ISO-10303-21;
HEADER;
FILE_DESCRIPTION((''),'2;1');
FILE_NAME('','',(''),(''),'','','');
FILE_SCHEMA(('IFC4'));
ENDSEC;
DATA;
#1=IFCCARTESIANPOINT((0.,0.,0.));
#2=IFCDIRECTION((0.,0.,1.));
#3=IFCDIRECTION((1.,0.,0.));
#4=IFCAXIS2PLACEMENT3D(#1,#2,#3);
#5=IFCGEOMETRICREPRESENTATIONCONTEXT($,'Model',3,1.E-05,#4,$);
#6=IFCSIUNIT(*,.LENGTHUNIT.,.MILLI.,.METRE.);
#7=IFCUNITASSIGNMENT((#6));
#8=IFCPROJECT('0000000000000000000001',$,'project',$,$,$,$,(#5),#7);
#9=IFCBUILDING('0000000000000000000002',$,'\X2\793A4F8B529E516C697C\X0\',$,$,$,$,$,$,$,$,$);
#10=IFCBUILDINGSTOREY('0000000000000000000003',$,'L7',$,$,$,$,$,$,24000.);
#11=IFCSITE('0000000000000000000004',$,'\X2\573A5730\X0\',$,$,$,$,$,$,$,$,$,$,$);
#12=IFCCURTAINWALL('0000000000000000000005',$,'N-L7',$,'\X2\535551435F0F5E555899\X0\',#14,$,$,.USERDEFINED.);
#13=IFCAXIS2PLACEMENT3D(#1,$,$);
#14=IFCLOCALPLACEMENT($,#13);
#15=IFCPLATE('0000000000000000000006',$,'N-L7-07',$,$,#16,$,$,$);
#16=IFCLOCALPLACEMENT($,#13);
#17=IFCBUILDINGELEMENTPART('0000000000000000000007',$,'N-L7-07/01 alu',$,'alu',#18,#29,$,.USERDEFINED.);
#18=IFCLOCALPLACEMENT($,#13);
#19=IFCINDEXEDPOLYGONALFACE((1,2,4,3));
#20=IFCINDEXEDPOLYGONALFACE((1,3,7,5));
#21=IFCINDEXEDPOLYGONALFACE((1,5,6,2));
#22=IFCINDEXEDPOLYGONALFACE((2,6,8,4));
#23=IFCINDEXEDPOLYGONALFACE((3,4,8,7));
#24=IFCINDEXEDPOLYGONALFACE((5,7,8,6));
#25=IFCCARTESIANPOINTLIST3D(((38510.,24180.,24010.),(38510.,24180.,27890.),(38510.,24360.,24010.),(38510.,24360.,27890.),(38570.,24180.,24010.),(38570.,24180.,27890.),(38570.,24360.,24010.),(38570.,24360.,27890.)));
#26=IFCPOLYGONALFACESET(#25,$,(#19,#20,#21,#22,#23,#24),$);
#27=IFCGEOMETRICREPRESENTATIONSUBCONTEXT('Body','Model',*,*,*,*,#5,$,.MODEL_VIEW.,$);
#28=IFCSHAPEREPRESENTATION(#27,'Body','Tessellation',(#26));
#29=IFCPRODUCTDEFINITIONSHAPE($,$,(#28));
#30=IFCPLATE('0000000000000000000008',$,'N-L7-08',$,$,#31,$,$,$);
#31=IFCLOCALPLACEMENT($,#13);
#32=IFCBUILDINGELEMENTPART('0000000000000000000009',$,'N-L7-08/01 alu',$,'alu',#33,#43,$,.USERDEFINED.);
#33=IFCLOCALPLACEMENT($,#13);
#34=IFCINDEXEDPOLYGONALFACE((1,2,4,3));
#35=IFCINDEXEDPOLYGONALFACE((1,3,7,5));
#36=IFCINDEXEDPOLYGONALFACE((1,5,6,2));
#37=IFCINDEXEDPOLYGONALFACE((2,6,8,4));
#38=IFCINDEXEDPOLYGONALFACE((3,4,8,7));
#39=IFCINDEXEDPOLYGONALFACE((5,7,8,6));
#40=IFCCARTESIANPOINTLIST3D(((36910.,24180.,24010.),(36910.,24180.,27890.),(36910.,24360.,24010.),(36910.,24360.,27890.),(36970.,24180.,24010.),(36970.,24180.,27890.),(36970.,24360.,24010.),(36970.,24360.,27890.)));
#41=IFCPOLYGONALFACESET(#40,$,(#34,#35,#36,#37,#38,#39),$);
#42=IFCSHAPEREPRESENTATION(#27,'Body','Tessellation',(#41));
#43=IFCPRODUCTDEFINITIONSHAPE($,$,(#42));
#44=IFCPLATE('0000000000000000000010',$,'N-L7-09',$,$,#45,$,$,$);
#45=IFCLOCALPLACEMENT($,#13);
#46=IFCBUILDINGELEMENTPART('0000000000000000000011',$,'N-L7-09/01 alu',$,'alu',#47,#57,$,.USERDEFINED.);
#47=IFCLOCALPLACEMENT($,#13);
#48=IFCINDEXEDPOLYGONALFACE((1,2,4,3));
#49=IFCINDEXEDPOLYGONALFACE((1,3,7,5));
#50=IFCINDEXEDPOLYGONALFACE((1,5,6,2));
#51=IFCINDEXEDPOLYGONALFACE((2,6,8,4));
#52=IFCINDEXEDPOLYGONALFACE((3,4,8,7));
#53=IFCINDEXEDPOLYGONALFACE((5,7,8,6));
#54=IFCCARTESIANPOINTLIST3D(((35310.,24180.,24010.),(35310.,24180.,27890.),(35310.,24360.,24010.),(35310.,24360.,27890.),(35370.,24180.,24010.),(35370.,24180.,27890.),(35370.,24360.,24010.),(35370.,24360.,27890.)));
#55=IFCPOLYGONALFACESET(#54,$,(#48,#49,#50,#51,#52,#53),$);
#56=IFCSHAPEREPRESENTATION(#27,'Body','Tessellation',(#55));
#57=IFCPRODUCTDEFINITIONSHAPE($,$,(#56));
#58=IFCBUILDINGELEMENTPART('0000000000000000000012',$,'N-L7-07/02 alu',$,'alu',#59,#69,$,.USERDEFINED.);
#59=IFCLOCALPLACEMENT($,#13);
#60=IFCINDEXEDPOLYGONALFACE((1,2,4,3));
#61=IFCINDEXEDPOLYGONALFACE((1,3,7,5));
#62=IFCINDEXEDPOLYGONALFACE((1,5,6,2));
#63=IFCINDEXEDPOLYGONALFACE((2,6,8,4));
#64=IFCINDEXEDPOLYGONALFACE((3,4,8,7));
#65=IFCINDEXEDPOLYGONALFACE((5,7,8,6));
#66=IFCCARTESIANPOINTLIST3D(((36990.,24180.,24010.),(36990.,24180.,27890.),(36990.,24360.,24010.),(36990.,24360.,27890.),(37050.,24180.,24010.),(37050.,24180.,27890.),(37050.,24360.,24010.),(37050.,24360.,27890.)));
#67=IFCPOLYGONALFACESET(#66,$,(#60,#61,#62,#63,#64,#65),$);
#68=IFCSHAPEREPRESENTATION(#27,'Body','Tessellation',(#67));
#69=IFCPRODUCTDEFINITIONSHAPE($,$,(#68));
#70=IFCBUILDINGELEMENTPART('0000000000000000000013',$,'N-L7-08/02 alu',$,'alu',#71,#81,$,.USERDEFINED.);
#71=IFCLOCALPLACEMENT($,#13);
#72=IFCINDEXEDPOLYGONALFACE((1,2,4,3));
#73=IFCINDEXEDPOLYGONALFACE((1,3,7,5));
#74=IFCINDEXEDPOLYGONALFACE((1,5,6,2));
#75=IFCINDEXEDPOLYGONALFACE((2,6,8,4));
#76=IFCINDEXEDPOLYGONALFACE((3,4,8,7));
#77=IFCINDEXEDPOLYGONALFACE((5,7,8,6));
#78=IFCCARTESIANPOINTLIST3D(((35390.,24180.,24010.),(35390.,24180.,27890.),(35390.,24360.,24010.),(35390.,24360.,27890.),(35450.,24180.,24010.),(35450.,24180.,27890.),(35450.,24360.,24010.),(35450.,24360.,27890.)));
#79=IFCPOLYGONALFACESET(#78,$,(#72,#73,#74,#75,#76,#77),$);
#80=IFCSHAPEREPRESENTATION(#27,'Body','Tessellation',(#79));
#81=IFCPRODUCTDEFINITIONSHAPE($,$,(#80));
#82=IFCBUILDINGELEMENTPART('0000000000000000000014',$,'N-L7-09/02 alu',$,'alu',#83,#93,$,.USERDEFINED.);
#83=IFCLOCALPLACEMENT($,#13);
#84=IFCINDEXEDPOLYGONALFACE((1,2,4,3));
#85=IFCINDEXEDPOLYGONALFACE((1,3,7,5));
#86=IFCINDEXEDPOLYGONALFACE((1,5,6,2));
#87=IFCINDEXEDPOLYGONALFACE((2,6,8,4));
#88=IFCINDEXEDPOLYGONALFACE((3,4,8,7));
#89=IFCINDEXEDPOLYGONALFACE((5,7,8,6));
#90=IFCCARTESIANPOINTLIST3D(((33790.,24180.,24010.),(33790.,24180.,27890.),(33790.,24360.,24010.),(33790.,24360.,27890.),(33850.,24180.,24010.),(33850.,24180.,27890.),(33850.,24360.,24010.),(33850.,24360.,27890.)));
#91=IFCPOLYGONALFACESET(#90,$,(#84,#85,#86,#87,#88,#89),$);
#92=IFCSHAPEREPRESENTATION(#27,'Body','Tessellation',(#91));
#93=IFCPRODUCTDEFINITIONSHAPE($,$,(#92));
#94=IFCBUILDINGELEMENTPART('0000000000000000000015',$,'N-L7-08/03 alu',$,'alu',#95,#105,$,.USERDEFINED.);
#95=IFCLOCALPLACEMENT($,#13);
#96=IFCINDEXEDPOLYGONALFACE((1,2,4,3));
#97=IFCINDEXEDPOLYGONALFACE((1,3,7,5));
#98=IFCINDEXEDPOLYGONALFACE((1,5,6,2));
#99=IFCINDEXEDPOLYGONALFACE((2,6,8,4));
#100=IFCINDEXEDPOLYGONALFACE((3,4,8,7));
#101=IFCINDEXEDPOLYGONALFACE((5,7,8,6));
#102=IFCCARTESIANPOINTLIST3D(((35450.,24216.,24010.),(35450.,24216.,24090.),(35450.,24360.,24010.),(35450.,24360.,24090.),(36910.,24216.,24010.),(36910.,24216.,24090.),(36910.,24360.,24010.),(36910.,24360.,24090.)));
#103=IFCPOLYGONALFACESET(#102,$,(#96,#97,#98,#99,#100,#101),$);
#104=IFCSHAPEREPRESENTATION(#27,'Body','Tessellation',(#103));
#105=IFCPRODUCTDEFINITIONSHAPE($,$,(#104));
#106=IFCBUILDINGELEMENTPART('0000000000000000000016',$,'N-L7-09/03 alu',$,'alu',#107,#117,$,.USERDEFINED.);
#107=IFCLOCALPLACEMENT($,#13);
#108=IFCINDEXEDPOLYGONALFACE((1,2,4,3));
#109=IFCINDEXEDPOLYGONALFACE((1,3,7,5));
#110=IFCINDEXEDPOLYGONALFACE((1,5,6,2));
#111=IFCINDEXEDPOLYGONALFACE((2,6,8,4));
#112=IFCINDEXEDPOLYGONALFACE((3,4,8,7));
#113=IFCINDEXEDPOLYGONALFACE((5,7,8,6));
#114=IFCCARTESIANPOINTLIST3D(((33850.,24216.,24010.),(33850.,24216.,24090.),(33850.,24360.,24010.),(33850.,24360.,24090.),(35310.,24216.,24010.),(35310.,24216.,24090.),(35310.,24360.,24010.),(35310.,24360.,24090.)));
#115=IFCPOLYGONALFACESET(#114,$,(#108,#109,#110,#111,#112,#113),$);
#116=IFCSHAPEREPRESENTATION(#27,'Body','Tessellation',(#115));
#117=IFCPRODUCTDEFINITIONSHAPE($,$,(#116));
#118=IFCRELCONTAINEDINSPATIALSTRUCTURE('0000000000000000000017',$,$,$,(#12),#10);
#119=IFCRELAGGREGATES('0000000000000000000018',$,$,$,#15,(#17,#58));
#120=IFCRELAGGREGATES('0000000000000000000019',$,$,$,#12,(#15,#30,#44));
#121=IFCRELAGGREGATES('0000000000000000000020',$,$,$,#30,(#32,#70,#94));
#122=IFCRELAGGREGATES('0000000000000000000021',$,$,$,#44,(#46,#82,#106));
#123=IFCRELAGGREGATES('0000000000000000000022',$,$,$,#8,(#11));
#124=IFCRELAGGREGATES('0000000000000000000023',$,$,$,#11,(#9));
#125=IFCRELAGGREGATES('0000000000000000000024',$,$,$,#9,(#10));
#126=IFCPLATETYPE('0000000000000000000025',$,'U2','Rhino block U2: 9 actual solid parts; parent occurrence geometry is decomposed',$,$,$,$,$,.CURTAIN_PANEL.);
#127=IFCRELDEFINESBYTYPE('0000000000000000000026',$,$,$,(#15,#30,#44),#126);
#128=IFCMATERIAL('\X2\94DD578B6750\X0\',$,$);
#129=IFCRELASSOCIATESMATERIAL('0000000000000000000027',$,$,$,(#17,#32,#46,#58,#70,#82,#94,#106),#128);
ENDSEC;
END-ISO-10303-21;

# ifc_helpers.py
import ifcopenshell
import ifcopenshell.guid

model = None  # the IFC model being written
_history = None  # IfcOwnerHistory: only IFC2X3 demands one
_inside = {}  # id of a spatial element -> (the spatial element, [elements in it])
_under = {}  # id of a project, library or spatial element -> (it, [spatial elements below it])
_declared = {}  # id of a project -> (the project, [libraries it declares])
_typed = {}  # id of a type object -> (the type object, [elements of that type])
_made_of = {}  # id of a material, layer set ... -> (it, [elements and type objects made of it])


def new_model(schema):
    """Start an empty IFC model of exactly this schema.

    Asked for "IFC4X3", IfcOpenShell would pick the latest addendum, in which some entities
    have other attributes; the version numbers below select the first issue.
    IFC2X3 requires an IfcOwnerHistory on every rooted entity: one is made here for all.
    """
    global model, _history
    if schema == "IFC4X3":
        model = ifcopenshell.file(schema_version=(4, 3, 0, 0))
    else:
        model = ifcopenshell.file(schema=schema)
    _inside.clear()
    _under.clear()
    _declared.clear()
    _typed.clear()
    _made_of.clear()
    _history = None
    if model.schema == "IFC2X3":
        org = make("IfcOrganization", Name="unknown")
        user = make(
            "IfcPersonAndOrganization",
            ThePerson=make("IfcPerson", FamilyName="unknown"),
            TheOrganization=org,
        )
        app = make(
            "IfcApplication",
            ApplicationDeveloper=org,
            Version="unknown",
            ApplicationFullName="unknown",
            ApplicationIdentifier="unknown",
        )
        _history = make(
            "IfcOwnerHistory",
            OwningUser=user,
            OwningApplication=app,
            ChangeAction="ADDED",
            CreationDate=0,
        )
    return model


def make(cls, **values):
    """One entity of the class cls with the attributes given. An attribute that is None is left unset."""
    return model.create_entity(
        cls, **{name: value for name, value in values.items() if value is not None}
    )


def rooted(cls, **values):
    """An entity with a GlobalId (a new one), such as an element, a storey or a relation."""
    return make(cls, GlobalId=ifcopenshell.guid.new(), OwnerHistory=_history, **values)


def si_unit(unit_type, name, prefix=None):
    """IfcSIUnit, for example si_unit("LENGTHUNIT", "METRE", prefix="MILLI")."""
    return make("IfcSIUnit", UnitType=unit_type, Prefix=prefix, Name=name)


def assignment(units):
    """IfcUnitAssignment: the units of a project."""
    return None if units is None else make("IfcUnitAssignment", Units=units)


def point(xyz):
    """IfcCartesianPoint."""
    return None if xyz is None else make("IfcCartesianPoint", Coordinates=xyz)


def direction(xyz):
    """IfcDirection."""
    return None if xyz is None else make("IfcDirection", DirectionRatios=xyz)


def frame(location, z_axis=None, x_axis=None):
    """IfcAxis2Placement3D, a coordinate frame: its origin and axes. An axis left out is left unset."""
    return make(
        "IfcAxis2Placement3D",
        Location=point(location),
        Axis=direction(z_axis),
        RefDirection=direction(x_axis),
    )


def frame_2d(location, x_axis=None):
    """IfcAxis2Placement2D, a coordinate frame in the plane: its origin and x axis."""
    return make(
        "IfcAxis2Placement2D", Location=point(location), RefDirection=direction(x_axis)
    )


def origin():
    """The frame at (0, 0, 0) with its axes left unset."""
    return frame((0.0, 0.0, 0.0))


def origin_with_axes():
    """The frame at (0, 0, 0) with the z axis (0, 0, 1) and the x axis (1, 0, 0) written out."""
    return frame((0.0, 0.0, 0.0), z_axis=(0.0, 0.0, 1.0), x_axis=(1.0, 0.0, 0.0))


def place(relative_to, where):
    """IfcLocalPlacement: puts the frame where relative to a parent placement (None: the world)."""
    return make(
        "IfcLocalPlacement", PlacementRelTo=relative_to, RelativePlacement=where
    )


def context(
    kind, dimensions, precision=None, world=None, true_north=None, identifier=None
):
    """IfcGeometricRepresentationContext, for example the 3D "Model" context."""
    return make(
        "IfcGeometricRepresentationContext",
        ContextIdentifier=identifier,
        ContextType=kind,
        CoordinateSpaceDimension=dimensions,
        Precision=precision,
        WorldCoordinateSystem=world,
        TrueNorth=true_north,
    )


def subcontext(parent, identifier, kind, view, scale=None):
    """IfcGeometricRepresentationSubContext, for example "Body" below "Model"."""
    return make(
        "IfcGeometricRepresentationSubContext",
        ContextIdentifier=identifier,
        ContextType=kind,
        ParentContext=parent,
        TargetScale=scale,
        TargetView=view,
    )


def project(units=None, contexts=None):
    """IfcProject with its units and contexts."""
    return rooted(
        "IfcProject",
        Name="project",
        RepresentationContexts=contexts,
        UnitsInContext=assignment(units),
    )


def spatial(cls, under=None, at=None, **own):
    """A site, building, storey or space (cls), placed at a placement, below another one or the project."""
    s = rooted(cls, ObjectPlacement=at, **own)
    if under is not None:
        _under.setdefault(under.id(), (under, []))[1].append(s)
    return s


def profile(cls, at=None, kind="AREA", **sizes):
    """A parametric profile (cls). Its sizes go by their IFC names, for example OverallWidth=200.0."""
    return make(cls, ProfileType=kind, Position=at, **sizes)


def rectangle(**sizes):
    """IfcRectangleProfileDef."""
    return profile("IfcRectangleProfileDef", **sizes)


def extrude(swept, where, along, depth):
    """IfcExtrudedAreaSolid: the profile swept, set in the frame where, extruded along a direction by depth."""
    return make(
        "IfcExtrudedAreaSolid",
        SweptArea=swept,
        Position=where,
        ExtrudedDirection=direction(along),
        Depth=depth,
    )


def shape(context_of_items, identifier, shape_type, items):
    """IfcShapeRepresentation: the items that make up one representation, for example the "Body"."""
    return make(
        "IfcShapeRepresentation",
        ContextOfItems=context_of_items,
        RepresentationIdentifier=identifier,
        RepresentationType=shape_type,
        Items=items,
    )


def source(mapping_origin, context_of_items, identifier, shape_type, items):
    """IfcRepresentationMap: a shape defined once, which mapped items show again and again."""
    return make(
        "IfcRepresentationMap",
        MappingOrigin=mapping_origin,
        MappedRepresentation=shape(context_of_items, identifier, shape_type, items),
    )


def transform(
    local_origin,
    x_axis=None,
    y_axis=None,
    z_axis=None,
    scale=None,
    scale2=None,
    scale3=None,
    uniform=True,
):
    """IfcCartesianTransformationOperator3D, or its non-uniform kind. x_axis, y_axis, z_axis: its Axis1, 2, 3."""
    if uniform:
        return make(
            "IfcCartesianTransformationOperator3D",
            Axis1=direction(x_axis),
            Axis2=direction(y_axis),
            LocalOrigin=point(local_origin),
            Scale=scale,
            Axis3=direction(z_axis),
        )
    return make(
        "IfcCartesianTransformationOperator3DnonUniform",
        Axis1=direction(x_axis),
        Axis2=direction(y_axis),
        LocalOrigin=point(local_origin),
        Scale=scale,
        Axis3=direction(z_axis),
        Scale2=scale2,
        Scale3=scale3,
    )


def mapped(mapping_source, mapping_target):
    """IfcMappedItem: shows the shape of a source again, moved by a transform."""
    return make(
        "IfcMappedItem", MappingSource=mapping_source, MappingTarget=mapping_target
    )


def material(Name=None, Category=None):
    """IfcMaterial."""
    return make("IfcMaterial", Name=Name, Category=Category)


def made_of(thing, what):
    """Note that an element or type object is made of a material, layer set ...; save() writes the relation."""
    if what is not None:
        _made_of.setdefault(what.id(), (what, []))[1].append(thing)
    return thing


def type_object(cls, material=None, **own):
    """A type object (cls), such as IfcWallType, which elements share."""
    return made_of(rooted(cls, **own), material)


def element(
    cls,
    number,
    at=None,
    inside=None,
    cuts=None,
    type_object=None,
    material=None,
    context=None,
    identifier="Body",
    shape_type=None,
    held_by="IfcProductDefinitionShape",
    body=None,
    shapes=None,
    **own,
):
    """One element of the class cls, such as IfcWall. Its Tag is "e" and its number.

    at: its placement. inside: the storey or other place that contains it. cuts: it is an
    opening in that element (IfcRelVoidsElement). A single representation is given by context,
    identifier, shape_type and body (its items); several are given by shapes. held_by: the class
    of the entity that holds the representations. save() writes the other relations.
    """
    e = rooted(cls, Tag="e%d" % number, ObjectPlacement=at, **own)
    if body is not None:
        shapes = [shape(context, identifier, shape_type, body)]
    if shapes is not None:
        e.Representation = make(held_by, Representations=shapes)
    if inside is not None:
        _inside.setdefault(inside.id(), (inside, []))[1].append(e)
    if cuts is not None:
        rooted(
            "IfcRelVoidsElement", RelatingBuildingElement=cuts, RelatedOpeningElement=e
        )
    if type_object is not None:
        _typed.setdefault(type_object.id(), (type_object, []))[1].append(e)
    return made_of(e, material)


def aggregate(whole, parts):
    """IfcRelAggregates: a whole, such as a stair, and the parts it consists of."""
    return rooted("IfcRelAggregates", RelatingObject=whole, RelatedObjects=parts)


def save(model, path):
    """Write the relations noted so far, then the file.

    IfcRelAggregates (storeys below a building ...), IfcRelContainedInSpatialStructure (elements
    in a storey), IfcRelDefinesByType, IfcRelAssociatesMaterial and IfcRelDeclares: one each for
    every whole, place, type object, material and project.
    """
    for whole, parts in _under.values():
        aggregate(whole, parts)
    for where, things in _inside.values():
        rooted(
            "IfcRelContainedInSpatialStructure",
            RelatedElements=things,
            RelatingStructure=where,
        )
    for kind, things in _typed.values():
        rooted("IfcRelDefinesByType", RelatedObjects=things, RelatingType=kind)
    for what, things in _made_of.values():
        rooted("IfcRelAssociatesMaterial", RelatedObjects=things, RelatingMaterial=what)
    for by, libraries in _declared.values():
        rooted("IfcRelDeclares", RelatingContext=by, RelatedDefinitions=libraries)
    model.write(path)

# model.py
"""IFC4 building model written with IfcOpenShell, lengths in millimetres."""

from ifc_helpers import new_model, si_unit, frame, frame_2d, origin, origin_with_axes, place, context, subcontext, project, spatial, rectangle, extrude, source, transform, mapped, material, type_object, element, aggregate, save


model = new_model("IFC4")

# Units and contexts
model_context = context("Model", 3, precision=1e-05, world=origin_with_axes())
body_context = subcontext(model_context, "Body", "Model", "MODEL_VIEW")
ifc_project = project(units=[si_unit("LENGTHUNIT", "METRE", prefix="MILLI")], contexts=[model_context])

# Site, building, storey
site = spatial("IfcSite", under=ifc_project, Name="场地")
building = spatial("IfcBuilding", under=site, Name="示例办公楼")
storey = spatial("IfcBuildingStorey", under=building, Name="L7", Elevation=24000.0)

# Curtain wall, plates, building element parts
curtain_wall = element("IfcCurtainWall", 1, inside=storey, Name="N-L7", ObjectType="单元式幕墙", PredefinedType="USERDEFINED")
plate_type = type_object("IfcPlateType", Name="U2", Description="Rhino block U2: 9 actual solid parts; parent occurrence geometry is decomposed", PredefinedType="CURTAIN_PANEL")
plate_1_placement = place(None, frame((38570.0, 24360.0, 24010.0), z_axis=(0.0, 0.0, 1.0), x_axis=(-1.0, 0.0, 0.0)))
plate_1 = element("IfcPlate", 2, at=plate_1_placement, type_object=plate_type, Name="N-L7-07")
ifc_material_1 = material(Name="铝型材")
shared_shape_1 = source(origin(), body_context, "Body", "SweptSolid", [
    extrude(rectangle(XDim=60.0, YDim=180.0, at=frame_2d((30.0, 90.0))), origin(), (0.0, 0.0, 1.0), 3880.0),
])
building_element_part_1_placement = place(plate_1_placement, origin())
building_element_part_1 = element("IfcBuildingElementPart", 3, at=building_element_part_1_placement, material=ifc_material_1, Name="N-L7-07/01 alu", ObjectType="alu", PredefinedType="USERDEFINED", context=body_context, shape_type="MappedRepresentation", body=[
    mapped(shared_shape_1, transform((0.0, 0.0, 0.0))),
])
plate_2_placement = place(None, frame((36970.0, 24360.0, 24010.0), z_axis=(0.0, 0.0, 1.0), x_axis=(-1.0, 0.0, 0.0)))
plate_2 = element("IfcPlate", 4, at=plate_2_placement, type_object=plate_type, Name="N-L7-08")
building_element_part_2_placement = place(plate_2_placement, origin())
building_element_part_2 = element("IfcBuildingElementPart", 5, at=building_element_part_2_placement, material=ifc_material_1, Name="N-L7-08/01 alu", ObjectType="alu", PredefinedType="USERDEFINED", context=body_context, shape_type="MappedRepresentation", body=[
    mapped(shared_shape_1, transform((0.0, 0.0, 0.0))),
])
plate_3_placement = place(None, frame((35370.0, 24360.0, 24010.0), z_axis=(0.0, 0.0, 1.0), x_axis=(-1.0, 0.0, 0.0)))
plate_3 = element("IfcPlate", 6, at=plate_3_placement, type_object=plate_type, Name="N-L7-09")
building_element_part_3_placement = place(plate_3_placement, origin())
building_element_part_3 = element("IfcBuildingElementPart", 7, at=building_element_part_3_placement, material=ifc_material_1, Name="N-L7-09/01 alu", ObjectType="alu", PredefinedType="USERDEFINED", context=body_context, shape_type="MappedRepresentation", body=[
    mapped(shared_shape_1, transform((0.0, 0.0, 0.0))),
])
shared_shape_2 = source(origin(), body_context, "Body", "SweptSolid", [
    extrude(rectangle(XDim=60.0, YDim=180.0, at=frame_2d((1550.0, 90.0))), origin(), (0.0, 0.0, 1.0), 3880.0),
])
building_element_part_4_placement = place(plate_1_placement, origin())
building_element_part_4 = element("IfcBuildingElementPart", 8, at=building_element_part_4_placement, material=ifc_material_1, Name="N-L7-07/02 alu", ObjectType="alu", PredefinedType="USERDEFINED", context=body_context, shape_type="MappedRepresentation", body=[
    mapped(shared_shape_2, transform((0.0, 0.0, 0.0))),
])
aggregate(plate_1, [building_element_part_1, building_element_part_4])
building_element_part_5_placement = place(plate_2_placement, origin())
building_element_part_5 = element("IfcBuildingElementPart", 9, at=building_element_part_5_placement, material=ifc_material_1, Name="N-L7-08/02 alu", ObjectType="alu", PredefinedType="USERDEFINED", context=body_context, shape_type="MappedRepresentation", body=[
    mapped(shared_shape_2, transform((0.0, 0.0, 0.0))),
])
building_element_part_6_placement = place(plate_3_placement, origin())
building_element_part_6 = element("IfcBuildingElementPart", 10, at=building_element_part_6_placement, material=ifc_material_1, Name="N-L7-09/02 alu", ObjectType="alu", PredefinedType="USERDEFINED", context=body_context, shape_type="MappedRepresentation", body=[
    mapped(shared_shape_2, transform((0.0, 0.0, 0.0))),
])
shared_shape_3 = source(origin(), body_context, "Body", "SweptSolid", [
    extrude(rectangle(XDim=1460.0, YDim=144.0, at=frame_2d((790.0, 72.0))), origin(), (0.0, 0.0, 1.0), 80.0),
])
building_element_part_7_placement = place(plate_2_placement, origin())
building_element_part_7 = element("IfcBuildingElementPart", 11, at=building_element_part_7_placement, material=ifc_material_1, Name="N-L7-08/03 alu", ObjectType="alu", PredefinedType="USERDEFINED", context=body_context, shape_type="MappedRepresentation", body=[
    mapped(shared_shape_3, transform((0.0, 0.0, 0.0))),
])
building_element_part_8_placement = place(plate_3_placement, origin())
building_element_part_8 = element("IfcBuildingElementPart", 12, at=building_element_part_8_placement, material=ifc_material_1, Name="N-L7-09/03 alu", ObjectType="alu", PredefinedType="USERDEFINED", context=body_context, shape_type="MappedRepresentation", body=[
    mapped(shared_shape_3, transform((0.0, 0.0, 0.0))),
])
aggregate(curtain_wall, [plate_1, plate_2, plate_3])
aggregate(plate_2, [building_element_part_2, building_element_part_5, building_element_part_7])
aggregate(plate_3, [building_element_part_3, building_element_part_6, building_element_part_8])

save(model, "model.ifc")
